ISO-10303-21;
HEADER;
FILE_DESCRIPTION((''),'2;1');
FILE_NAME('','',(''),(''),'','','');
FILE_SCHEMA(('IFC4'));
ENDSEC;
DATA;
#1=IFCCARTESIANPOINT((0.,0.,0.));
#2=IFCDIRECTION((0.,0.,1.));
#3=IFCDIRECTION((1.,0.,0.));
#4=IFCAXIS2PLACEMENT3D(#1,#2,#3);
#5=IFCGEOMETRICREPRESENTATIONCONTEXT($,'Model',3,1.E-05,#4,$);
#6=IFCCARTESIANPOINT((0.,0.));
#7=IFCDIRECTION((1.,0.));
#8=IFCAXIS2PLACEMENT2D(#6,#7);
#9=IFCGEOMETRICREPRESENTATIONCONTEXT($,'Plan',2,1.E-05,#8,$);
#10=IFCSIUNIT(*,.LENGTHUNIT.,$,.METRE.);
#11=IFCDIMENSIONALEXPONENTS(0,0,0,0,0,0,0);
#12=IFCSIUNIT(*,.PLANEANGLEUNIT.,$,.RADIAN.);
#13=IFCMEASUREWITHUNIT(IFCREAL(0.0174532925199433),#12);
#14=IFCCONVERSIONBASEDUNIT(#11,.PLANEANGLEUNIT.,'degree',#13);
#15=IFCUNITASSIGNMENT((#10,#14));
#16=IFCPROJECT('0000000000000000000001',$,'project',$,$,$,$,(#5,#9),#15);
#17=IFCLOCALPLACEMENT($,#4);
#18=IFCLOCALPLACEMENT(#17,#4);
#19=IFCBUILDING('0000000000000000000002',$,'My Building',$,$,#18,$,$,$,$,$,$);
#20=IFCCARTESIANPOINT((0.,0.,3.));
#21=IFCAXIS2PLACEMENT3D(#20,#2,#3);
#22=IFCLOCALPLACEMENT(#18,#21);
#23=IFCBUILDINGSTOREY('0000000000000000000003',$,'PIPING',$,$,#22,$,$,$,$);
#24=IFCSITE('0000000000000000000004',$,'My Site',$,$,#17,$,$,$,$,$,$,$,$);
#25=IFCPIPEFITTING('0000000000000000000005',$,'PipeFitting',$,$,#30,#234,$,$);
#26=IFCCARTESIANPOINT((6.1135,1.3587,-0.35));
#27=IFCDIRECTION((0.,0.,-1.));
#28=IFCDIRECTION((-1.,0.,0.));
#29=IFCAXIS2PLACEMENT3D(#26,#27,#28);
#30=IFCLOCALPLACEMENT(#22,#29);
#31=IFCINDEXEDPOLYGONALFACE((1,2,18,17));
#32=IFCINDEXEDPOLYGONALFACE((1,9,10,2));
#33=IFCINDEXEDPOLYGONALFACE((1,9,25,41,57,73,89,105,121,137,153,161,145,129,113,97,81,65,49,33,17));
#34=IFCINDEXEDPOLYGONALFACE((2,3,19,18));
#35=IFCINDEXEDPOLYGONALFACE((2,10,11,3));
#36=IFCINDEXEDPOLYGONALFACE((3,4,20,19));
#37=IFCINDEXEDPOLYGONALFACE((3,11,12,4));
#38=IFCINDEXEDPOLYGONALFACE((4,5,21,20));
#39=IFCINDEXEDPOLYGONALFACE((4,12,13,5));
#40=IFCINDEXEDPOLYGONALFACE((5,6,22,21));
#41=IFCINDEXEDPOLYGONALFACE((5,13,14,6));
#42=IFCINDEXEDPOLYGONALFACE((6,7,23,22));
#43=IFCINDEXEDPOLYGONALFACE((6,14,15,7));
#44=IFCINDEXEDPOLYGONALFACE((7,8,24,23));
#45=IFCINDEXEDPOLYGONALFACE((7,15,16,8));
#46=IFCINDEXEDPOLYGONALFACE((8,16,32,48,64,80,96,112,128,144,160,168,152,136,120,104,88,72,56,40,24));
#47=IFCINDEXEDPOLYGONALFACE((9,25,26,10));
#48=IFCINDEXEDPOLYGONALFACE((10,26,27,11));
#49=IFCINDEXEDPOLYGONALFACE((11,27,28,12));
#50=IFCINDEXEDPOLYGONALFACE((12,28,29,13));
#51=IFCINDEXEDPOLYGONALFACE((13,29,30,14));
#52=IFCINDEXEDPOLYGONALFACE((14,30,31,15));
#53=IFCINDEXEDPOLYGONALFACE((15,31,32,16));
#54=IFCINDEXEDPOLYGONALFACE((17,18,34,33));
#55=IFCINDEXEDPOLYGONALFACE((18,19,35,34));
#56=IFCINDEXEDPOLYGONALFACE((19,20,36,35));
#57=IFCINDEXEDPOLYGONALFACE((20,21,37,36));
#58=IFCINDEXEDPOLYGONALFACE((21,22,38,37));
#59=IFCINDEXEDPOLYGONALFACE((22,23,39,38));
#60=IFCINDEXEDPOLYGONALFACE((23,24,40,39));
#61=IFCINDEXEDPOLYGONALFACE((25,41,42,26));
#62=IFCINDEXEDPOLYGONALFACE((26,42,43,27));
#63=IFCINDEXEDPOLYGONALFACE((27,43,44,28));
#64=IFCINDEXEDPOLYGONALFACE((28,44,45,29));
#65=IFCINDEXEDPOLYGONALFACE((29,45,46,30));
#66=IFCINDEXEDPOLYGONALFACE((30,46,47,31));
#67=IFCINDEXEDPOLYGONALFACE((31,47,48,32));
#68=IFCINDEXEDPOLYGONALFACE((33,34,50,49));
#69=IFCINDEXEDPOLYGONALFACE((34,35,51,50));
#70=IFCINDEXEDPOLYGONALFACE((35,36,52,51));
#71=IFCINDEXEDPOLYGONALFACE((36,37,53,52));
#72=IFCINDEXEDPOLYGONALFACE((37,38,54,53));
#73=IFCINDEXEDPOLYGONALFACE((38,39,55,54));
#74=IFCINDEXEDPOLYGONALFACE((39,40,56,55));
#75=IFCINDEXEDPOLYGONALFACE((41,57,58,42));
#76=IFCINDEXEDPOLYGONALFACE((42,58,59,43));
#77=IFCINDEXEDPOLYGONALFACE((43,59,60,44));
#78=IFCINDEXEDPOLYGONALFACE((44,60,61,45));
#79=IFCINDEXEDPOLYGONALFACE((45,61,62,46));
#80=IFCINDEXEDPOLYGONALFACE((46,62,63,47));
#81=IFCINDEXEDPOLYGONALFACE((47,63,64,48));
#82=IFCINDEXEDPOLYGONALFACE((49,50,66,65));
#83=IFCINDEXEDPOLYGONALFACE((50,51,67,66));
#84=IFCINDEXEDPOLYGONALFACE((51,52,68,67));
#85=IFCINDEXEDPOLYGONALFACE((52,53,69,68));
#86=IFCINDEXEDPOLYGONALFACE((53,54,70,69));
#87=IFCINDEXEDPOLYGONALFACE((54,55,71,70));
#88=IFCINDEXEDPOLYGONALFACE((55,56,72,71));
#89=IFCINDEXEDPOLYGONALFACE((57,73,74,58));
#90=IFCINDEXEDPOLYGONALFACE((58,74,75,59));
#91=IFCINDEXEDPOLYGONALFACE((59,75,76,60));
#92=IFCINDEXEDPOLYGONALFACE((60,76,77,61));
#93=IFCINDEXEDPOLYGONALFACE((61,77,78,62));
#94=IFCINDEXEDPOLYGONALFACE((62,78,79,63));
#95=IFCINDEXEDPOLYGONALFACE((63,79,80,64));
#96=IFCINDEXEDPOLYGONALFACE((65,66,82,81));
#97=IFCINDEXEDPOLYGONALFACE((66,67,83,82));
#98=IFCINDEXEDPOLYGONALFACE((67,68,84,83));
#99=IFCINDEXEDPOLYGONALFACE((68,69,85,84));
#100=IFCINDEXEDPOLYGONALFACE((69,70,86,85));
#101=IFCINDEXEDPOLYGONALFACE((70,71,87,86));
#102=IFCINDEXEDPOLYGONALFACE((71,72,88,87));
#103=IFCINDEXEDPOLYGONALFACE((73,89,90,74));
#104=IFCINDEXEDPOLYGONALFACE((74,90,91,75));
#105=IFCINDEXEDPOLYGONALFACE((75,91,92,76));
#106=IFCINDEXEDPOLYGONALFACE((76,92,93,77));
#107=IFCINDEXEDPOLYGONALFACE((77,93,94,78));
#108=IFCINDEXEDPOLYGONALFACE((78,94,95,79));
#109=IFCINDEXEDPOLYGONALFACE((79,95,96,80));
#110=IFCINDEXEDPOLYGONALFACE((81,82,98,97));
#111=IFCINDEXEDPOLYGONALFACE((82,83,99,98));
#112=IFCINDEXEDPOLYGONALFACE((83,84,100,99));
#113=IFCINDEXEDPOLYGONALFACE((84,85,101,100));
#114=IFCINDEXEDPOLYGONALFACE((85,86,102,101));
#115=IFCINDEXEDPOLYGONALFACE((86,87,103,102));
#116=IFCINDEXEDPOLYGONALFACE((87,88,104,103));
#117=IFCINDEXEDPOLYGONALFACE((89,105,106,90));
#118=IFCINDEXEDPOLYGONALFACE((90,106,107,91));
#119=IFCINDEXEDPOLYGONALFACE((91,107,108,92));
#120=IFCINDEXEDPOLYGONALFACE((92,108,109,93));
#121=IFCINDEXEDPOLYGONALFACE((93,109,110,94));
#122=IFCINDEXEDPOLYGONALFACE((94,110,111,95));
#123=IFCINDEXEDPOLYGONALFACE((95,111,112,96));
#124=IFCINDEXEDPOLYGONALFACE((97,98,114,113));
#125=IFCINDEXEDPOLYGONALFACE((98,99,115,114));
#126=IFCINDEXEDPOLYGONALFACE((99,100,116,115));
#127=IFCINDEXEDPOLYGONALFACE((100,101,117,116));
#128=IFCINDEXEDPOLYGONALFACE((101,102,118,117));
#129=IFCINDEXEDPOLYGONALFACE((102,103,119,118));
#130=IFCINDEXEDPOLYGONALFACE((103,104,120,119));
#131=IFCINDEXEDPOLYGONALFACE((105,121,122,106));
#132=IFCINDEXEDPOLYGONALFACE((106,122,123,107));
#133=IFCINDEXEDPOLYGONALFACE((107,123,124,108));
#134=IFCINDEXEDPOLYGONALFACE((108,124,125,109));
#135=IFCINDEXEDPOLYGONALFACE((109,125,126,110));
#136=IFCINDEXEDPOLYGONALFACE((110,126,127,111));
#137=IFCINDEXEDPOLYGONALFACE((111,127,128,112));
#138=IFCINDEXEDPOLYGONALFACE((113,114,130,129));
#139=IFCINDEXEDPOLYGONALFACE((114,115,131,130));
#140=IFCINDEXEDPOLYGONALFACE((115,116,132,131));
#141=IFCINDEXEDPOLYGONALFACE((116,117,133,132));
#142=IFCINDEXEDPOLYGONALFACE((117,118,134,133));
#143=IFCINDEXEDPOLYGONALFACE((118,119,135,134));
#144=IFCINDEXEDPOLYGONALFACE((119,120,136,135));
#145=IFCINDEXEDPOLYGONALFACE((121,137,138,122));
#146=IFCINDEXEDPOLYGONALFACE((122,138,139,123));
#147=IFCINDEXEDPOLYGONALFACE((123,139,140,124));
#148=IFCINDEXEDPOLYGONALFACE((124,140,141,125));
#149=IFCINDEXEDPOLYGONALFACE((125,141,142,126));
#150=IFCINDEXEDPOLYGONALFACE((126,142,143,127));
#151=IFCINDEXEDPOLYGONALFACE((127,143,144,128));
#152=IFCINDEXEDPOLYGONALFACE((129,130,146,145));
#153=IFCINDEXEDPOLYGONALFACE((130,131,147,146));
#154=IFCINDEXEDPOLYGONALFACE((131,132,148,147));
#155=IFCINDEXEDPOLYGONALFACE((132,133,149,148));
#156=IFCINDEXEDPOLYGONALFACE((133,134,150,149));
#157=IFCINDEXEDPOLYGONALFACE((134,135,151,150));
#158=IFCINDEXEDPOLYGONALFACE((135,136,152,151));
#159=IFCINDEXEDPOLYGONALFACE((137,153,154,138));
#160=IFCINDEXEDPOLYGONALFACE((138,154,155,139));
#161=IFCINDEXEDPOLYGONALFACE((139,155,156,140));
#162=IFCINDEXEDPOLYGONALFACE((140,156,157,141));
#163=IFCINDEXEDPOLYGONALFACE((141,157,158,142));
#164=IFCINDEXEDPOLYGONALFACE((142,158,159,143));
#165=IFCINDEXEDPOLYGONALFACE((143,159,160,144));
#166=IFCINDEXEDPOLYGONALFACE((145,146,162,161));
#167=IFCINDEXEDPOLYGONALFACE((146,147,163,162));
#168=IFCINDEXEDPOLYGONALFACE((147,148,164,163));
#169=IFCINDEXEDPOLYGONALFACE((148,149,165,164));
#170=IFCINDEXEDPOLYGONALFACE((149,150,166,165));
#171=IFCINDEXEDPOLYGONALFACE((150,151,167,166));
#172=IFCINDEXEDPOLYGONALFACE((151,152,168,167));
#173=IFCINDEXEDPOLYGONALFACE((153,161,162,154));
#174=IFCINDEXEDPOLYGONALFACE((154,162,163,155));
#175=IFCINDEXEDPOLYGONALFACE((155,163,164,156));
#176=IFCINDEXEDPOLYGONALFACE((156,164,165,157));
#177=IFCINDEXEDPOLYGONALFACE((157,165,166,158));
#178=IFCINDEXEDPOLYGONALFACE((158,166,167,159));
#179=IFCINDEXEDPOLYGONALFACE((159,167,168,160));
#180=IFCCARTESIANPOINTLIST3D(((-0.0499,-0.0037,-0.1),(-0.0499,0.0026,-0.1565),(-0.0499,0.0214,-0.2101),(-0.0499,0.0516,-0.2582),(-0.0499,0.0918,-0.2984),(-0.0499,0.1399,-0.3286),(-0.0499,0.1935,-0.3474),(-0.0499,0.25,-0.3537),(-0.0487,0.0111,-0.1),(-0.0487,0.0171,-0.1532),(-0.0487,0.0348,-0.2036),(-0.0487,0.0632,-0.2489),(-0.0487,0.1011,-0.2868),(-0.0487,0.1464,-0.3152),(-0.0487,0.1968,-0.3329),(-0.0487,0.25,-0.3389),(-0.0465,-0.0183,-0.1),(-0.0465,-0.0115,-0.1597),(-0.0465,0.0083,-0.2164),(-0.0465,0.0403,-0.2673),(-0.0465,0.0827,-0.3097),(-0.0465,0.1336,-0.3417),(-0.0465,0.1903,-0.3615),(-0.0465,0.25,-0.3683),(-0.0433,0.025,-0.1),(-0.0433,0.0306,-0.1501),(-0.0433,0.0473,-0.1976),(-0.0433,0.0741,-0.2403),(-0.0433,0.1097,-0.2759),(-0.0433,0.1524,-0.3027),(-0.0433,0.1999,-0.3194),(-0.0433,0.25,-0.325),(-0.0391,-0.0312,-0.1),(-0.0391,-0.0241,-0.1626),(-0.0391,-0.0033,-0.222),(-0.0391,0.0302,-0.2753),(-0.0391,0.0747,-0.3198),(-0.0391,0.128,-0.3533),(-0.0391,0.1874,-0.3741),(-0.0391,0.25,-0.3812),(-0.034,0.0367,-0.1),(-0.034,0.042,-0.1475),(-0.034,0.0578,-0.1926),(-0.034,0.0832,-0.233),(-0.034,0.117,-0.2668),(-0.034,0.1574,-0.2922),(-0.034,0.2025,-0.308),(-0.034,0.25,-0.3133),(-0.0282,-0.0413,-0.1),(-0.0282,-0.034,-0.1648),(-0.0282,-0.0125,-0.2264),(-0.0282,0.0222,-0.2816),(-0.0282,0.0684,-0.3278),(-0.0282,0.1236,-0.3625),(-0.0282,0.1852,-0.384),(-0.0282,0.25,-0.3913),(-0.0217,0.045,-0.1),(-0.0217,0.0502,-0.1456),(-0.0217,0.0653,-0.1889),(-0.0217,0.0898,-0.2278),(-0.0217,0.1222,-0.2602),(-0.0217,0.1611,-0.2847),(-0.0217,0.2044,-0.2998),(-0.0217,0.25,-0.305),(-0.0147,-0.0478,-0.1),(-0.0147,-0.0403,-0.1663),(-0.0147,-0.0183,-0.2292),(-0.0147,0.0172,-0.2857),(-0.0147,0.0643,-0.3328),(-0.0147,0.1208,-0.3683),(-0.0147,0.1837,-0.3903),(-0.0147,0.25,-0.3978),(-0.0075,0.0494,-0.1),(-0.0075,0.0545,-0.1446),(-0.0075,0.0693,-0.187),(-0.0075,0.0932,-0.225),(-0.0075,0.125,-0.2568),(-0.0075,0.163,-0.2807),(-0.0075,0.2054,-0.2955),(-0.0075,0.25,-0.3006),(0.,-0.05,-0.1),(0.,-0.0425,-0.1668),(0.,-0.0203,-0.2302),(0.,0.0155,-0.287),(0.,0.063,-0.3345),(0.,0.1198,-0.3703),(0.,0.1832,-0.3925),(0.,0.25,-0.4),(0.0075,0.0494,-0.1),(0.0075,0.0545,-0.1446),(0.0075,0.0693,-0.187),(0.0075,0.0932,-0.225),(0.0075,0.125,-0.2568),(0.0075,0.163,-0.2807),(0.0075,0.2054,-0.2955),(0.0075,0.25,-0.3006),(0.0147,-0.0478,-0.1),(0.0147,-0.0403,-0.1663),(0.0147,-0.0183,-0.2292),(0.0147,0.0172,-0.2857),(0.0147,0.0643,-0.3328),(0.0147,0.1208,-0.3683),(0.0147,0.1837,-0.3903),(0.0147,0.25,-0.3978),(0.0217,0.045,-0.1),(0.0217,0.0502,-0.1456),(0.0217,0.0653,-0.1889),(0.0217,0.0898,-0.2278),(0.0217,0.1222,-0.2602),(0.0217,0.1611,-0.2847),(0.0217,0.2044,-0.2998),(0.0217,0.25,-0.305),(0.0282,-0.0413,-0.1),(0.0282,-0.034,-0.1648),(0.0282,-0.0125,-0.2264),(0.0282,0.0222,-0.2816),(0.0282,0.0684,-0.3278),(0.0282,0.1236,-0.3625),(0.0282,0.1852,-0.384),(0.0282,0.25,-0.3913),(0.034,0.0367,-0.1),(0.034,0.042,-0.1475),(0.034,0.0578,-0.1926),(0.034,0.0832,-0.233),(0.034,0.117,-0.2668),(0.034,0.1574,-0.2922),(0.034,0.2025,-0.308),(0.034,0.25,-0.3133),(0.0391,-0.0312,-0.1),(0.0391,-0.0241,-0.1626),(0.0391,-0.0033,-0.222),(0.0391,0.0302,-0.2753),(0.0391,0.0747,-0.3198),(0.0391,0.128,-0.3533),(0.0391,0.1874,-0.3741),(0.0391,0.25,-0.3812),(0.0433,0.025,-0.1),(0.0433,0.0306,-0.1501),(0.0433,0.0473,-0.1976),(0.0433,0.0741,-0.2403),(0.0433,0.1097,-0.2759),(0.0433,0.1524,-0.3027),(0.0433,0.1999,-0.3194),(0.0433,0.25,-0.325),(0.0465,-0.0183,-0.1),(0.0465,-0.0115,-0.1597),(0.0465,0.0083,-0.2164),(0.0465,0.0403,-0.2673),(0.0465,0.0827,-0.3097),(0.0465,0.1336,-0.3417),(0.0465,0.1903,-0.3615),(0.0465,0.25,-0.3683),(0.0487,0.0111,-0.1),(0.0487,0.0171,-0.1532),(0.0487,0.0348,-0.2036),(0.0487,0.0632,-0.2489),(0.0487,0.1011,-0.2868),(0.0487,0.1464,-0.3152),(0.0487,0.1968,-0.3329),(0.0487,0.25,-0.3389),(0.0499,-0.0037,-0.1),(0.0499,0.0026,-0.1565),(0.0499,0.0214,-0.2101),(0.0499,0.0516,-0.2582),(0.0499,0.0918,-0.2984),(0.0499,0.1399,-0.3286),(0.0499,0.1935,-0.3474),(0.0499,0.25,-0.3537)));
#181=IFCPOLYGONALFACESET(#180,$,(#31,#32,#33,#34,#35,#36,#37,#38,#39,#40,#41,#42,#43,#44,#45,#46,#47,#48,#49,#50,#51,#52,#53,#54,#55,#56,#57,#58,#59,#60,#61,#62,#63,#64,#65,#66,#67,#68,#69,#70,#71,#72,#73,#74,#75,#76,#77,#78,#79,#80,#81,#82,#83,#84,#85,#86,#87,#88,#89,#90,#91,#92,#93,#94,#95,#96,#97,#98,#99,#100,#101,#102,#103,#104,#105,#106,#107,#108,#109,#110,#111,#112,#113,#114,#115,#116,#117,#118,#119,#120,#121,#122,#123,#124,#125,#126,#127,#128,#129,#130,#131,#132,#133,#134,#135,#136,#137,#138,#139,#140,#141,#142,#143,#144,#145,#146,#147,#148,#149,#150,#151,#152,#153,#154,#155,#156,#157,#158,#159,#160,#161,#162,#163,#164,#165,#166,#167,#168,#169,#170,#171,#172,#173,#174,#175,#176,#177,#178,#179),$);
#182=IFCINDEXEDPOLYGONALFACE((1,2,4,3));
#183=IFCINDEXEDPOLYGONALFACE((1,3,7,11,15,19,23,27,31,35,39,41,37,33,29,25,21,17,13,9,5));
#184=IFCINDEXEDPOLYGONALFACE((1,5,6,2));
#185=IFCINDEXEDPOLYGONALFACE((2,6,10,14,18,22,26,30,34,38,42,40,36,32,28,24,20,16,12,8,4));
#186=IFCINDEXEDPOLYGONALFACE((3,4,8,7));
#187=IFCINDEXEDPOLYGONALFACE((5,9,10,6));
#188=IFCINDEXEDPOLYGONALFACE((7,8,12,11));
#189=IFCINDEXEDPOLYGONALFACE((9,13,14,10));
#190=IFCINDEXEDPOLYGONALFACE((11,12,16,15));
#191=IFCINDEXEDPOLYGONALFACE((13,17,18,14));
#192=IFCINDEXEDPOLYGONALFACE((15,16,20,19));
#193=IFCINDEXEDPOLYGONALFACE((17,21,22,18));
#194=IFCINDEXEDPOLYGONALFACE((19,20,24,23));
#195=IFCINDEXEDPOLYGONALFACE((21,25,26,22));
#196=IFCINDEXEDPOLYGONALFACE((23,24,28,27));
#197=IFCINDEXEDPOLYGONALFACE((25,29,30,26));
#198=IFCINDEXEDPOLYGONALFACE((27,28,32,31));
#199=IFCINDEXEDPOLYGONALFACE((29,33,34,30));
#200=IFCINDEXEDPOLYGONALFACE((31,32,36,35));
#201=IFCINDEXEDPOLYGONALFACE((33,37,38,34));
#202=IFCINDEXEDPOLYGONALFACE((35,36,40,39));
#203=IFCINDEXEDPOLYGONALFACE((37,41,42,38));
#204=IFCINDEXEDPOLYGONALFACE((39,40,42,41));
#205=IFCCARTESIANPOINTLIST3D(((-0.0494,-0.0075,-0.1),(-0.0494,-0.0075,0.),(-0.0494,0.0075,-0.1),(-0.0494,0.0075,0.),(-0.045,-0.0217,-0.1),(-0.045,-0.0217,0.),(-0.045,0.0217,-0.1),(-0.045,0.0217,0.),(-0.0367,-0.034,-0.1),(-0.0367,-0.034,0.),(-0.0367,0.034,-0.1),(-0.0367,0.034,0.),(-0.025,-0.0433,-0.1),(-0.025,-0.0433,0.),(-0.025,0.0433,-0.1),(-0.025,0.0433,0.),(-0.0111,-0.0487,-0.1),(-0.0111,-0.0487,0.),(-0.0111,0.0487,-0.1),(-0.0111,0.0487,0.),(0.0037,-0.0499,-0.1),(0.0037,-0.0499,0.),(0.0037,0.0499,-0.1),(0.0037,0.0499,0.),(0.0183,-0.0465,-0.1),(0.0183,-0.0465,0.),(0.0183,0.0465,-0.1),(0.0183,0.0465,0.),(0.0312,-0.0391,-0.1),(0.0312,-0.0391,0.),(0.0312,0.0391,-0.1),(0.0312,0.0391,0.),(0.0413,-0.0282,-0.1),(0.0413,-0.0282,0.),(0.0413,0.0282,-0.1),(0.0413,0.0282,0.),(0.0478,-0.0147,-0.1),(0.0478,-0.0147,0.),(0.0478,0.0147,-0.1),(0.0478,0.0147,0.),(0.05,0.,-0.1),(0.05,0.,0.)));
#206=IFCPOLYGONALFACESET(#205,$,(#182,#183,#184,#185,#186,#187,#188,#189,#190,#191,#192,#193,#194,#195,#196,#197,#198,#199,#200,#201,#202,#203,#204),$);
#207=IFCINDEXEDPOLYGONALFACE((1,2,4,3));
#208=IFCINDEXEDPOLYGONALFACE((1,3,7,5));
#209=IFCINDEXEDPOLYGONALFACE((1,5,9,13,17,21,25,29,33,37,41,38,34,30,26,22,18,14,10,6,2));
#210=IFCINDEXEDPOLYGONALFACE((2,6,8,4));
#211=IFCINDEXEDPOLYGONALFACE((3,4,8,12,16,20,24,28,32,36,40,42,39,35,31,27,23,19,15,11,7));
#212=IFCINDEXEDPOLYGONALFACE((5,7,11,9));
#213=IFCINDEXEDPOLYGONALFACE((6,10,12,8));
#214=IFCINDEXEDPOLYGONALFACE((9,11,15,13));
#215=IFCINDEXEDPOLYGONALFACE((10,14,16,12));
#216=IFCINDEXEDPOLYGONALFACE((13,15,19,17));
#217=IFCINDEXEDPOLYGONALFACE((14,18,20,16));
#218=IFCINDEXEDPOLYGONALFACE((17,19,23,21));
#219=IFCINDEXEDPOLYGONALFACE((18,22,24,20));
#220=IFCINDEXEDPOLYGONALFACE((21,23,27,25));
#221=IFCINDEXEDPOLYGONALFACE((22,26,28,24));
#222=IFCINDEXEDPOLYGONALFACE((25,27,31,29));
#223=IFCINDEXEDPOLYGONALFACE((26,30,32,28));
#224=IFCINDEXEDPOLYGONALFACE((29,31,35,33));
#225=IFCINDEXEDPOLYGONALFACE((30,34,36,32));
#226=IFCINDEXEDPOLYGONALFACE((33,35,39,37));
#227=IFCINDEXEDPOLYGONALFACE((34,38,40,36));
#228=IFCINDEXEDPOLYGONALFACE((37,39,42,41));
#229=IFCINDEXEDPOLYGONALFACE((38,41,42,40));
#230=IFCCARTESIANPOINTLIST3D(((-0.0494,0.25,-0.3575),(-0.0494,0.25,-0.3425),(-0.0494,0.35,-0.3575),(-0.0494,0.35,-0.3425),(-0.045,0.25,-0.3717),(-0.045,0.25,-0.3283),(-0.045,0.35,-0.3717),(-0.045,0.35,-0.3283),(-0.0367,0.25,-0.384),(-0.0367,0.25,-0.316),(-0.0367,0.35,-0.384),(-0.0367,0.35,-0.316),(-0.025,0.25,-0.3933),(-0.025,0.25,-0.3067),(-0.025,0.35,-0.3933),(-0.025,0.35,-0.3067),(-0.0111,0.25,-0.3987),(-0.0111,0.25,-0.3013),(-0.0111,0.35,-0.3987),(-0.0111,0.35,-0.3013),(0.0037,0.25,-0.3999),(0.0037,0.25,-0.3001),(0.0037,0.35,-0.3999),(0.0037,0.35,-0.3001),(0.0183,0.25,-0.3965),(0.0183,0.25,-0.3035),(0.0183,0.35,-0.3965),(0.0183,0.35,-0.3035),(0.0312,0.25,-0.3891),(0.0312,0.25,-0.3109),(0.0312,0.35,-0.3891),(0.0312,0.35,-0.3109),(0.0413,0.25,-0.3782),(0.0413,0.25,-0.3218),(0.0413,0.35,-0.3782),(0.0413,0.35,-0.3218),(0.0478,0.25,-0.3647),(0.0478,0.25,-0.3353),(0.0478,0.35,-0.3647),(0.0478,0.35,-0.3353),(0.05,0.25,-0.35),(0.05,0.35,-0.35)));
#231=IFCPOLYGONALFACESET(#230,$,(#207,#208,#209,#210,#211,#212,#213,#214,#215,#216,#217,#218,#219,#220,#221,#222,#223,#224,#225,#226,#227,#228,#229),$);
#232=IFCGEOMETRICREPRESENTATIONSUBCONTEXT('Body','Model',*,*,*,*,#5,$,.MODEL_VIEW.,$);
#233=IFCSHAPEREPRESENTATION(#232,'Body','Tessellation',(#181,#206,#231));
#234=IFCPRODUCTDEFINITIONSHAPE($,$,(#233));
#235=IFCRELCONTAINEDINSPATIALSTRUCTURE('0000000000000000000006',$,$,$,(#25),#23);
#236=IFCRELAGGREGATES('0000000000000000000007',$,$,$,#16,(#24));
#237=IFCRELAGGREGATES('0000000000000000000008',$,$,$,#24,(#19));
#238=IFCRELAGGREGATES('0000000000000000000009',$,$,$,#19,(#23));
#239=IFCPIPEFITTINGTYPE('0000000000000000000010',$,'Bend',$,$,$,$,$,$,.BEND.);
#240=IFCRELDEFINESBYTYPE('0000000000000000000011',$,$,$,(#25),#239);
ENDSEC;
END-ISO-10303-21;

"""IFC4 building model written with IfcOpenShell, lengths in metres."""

from ifc_helpers import new_model, entity, si_unit, converted_unit, frame, origin_with_axes, origin_2d_with_axis, place, context, subcontext, project, spatial, line, indexed_curve, circle, outline, extrude, source, transform, mapped, type_object, type_shapes, element, save


model = new_model("IFC4")

# Units and contexts
model_context = context("Model", 3, precision=1e-05, world=origin_with_axes())
plan_context = context("Plan", 2, precision=1e-05, world=origin_2d_with_axis())
body_context = subcontext(model_context, "Body", "Model", "MODEL_VIEW")
ifc_project = project(units=[si_unit("LENGTHUNIT", "METRE"), converted_unit("PLANEANGLEUNIT", "degree", entity("IfcReal", 0.0174532925199433), si_unit("PLANEANGLEUNIT", "RADIAN"), dimensions=[0, 0, 0, 0, 0, 0, 0])], contexts=[model_context, plan_context])

# Site, building, storey
site_placement = place(None, origin_with_axes())
site = spatial("IfcSite", under=ifc_project, at=site_placement, Name="My Site")
building_placement = place(site_placement, origin_with_axes())
building = spatial("IfcBuilding", under=site, at=building_placement, Name="My Building")
storey_placement = place(building_placement, frame((0.0, 0.0, 3.0), z_axis=(0.0, 0.0, 1.0), x_axis=(1.0, 0.0, 0.0)))
storey = spatial("IfcBuildingStorey", under=building, at=storey_placement, Name="PIPING")

# Shared definitions
pipe_fitting_type = type_object("IfcPipeFittingType", Name="Bend", PredefinedType="BEND")
shared_shape = source(origin_with_axes(), body_context, "Body", "SolidModel", [
    entity("IfcSweptDiskSolid", entity("IfcIndexedPolyCurve", entity("IfcCartesianPointList3D", [[0.0, 0.0, -0.1], [0.0, 0.0732, -0.2768], [0.0, 0.25, -0.35]]), [entity("IfcArcIndex", [1, 2, 3])]), 0.05),
    extrude(circle(Radius=0.05), origin_with_axes(), (0.0, 0.0, -1.0), 0.1),
    extrude(circle(Radius=0.05), frame((0.0, 0.25, -0.35), z_axis=(0.0, 1.0, 0.0), x_axis=(1.0, 0.0, 0.0)), (0.0, 0.0, 1.0), 0.1),
])
type_shapes(pipe_fitting_type, [shared_shape])

# Pipe fitting, opening
pipe_fitting_1_placement = place(storey_placement, frame((6.1135, 1.3587, -0.35), z_axis=(0.0, 0.0, -1.0), x_axis=(-1.0, 0.0, 0.0)))
pipe_fitting_1 = element("IfcPipeFitting", 1, at=pipe_fitting_1_placement, inside=storey, type_object=pipe_fitting_type, Name="PipeFitting", context=body_context, shape_type="MappedRepresentation", body=[
    mapped(shared_shape, transform((0.0, 0.0, 0.0), x_axis=(1.0, 0.0, 0.0), y_axis=(0.0, 1.0, 0.0), z_axis=(0.0, 0.0, 1.0), scale=1.0)),
])
opening_1_placement = place(pipe_fitting_1_placement, frame((1.768, -1.3587, 2.65), z_axis=(0.0, 0.0, -1.0), x_axis=(-1.0, 0.0, 0.0)))
element("IfcOpeningElement", 2, at=opening_1_placement, cuts=pipe_fitting_1, PredefinedType="OPENING", context=body_context, shape_type="SweptSolid", body=[
    extrude(outline(indexed_curve([(0.0, 0.0), (0.5, 0.0), (0.5, 0.5), (0.0, 0.5)], segments=[line(1, 2, 3, 4, 1)])), origin_with_axes(), (0.0, 0.0, 1.0), 0.5),
])

save(model, "model.ifc")
